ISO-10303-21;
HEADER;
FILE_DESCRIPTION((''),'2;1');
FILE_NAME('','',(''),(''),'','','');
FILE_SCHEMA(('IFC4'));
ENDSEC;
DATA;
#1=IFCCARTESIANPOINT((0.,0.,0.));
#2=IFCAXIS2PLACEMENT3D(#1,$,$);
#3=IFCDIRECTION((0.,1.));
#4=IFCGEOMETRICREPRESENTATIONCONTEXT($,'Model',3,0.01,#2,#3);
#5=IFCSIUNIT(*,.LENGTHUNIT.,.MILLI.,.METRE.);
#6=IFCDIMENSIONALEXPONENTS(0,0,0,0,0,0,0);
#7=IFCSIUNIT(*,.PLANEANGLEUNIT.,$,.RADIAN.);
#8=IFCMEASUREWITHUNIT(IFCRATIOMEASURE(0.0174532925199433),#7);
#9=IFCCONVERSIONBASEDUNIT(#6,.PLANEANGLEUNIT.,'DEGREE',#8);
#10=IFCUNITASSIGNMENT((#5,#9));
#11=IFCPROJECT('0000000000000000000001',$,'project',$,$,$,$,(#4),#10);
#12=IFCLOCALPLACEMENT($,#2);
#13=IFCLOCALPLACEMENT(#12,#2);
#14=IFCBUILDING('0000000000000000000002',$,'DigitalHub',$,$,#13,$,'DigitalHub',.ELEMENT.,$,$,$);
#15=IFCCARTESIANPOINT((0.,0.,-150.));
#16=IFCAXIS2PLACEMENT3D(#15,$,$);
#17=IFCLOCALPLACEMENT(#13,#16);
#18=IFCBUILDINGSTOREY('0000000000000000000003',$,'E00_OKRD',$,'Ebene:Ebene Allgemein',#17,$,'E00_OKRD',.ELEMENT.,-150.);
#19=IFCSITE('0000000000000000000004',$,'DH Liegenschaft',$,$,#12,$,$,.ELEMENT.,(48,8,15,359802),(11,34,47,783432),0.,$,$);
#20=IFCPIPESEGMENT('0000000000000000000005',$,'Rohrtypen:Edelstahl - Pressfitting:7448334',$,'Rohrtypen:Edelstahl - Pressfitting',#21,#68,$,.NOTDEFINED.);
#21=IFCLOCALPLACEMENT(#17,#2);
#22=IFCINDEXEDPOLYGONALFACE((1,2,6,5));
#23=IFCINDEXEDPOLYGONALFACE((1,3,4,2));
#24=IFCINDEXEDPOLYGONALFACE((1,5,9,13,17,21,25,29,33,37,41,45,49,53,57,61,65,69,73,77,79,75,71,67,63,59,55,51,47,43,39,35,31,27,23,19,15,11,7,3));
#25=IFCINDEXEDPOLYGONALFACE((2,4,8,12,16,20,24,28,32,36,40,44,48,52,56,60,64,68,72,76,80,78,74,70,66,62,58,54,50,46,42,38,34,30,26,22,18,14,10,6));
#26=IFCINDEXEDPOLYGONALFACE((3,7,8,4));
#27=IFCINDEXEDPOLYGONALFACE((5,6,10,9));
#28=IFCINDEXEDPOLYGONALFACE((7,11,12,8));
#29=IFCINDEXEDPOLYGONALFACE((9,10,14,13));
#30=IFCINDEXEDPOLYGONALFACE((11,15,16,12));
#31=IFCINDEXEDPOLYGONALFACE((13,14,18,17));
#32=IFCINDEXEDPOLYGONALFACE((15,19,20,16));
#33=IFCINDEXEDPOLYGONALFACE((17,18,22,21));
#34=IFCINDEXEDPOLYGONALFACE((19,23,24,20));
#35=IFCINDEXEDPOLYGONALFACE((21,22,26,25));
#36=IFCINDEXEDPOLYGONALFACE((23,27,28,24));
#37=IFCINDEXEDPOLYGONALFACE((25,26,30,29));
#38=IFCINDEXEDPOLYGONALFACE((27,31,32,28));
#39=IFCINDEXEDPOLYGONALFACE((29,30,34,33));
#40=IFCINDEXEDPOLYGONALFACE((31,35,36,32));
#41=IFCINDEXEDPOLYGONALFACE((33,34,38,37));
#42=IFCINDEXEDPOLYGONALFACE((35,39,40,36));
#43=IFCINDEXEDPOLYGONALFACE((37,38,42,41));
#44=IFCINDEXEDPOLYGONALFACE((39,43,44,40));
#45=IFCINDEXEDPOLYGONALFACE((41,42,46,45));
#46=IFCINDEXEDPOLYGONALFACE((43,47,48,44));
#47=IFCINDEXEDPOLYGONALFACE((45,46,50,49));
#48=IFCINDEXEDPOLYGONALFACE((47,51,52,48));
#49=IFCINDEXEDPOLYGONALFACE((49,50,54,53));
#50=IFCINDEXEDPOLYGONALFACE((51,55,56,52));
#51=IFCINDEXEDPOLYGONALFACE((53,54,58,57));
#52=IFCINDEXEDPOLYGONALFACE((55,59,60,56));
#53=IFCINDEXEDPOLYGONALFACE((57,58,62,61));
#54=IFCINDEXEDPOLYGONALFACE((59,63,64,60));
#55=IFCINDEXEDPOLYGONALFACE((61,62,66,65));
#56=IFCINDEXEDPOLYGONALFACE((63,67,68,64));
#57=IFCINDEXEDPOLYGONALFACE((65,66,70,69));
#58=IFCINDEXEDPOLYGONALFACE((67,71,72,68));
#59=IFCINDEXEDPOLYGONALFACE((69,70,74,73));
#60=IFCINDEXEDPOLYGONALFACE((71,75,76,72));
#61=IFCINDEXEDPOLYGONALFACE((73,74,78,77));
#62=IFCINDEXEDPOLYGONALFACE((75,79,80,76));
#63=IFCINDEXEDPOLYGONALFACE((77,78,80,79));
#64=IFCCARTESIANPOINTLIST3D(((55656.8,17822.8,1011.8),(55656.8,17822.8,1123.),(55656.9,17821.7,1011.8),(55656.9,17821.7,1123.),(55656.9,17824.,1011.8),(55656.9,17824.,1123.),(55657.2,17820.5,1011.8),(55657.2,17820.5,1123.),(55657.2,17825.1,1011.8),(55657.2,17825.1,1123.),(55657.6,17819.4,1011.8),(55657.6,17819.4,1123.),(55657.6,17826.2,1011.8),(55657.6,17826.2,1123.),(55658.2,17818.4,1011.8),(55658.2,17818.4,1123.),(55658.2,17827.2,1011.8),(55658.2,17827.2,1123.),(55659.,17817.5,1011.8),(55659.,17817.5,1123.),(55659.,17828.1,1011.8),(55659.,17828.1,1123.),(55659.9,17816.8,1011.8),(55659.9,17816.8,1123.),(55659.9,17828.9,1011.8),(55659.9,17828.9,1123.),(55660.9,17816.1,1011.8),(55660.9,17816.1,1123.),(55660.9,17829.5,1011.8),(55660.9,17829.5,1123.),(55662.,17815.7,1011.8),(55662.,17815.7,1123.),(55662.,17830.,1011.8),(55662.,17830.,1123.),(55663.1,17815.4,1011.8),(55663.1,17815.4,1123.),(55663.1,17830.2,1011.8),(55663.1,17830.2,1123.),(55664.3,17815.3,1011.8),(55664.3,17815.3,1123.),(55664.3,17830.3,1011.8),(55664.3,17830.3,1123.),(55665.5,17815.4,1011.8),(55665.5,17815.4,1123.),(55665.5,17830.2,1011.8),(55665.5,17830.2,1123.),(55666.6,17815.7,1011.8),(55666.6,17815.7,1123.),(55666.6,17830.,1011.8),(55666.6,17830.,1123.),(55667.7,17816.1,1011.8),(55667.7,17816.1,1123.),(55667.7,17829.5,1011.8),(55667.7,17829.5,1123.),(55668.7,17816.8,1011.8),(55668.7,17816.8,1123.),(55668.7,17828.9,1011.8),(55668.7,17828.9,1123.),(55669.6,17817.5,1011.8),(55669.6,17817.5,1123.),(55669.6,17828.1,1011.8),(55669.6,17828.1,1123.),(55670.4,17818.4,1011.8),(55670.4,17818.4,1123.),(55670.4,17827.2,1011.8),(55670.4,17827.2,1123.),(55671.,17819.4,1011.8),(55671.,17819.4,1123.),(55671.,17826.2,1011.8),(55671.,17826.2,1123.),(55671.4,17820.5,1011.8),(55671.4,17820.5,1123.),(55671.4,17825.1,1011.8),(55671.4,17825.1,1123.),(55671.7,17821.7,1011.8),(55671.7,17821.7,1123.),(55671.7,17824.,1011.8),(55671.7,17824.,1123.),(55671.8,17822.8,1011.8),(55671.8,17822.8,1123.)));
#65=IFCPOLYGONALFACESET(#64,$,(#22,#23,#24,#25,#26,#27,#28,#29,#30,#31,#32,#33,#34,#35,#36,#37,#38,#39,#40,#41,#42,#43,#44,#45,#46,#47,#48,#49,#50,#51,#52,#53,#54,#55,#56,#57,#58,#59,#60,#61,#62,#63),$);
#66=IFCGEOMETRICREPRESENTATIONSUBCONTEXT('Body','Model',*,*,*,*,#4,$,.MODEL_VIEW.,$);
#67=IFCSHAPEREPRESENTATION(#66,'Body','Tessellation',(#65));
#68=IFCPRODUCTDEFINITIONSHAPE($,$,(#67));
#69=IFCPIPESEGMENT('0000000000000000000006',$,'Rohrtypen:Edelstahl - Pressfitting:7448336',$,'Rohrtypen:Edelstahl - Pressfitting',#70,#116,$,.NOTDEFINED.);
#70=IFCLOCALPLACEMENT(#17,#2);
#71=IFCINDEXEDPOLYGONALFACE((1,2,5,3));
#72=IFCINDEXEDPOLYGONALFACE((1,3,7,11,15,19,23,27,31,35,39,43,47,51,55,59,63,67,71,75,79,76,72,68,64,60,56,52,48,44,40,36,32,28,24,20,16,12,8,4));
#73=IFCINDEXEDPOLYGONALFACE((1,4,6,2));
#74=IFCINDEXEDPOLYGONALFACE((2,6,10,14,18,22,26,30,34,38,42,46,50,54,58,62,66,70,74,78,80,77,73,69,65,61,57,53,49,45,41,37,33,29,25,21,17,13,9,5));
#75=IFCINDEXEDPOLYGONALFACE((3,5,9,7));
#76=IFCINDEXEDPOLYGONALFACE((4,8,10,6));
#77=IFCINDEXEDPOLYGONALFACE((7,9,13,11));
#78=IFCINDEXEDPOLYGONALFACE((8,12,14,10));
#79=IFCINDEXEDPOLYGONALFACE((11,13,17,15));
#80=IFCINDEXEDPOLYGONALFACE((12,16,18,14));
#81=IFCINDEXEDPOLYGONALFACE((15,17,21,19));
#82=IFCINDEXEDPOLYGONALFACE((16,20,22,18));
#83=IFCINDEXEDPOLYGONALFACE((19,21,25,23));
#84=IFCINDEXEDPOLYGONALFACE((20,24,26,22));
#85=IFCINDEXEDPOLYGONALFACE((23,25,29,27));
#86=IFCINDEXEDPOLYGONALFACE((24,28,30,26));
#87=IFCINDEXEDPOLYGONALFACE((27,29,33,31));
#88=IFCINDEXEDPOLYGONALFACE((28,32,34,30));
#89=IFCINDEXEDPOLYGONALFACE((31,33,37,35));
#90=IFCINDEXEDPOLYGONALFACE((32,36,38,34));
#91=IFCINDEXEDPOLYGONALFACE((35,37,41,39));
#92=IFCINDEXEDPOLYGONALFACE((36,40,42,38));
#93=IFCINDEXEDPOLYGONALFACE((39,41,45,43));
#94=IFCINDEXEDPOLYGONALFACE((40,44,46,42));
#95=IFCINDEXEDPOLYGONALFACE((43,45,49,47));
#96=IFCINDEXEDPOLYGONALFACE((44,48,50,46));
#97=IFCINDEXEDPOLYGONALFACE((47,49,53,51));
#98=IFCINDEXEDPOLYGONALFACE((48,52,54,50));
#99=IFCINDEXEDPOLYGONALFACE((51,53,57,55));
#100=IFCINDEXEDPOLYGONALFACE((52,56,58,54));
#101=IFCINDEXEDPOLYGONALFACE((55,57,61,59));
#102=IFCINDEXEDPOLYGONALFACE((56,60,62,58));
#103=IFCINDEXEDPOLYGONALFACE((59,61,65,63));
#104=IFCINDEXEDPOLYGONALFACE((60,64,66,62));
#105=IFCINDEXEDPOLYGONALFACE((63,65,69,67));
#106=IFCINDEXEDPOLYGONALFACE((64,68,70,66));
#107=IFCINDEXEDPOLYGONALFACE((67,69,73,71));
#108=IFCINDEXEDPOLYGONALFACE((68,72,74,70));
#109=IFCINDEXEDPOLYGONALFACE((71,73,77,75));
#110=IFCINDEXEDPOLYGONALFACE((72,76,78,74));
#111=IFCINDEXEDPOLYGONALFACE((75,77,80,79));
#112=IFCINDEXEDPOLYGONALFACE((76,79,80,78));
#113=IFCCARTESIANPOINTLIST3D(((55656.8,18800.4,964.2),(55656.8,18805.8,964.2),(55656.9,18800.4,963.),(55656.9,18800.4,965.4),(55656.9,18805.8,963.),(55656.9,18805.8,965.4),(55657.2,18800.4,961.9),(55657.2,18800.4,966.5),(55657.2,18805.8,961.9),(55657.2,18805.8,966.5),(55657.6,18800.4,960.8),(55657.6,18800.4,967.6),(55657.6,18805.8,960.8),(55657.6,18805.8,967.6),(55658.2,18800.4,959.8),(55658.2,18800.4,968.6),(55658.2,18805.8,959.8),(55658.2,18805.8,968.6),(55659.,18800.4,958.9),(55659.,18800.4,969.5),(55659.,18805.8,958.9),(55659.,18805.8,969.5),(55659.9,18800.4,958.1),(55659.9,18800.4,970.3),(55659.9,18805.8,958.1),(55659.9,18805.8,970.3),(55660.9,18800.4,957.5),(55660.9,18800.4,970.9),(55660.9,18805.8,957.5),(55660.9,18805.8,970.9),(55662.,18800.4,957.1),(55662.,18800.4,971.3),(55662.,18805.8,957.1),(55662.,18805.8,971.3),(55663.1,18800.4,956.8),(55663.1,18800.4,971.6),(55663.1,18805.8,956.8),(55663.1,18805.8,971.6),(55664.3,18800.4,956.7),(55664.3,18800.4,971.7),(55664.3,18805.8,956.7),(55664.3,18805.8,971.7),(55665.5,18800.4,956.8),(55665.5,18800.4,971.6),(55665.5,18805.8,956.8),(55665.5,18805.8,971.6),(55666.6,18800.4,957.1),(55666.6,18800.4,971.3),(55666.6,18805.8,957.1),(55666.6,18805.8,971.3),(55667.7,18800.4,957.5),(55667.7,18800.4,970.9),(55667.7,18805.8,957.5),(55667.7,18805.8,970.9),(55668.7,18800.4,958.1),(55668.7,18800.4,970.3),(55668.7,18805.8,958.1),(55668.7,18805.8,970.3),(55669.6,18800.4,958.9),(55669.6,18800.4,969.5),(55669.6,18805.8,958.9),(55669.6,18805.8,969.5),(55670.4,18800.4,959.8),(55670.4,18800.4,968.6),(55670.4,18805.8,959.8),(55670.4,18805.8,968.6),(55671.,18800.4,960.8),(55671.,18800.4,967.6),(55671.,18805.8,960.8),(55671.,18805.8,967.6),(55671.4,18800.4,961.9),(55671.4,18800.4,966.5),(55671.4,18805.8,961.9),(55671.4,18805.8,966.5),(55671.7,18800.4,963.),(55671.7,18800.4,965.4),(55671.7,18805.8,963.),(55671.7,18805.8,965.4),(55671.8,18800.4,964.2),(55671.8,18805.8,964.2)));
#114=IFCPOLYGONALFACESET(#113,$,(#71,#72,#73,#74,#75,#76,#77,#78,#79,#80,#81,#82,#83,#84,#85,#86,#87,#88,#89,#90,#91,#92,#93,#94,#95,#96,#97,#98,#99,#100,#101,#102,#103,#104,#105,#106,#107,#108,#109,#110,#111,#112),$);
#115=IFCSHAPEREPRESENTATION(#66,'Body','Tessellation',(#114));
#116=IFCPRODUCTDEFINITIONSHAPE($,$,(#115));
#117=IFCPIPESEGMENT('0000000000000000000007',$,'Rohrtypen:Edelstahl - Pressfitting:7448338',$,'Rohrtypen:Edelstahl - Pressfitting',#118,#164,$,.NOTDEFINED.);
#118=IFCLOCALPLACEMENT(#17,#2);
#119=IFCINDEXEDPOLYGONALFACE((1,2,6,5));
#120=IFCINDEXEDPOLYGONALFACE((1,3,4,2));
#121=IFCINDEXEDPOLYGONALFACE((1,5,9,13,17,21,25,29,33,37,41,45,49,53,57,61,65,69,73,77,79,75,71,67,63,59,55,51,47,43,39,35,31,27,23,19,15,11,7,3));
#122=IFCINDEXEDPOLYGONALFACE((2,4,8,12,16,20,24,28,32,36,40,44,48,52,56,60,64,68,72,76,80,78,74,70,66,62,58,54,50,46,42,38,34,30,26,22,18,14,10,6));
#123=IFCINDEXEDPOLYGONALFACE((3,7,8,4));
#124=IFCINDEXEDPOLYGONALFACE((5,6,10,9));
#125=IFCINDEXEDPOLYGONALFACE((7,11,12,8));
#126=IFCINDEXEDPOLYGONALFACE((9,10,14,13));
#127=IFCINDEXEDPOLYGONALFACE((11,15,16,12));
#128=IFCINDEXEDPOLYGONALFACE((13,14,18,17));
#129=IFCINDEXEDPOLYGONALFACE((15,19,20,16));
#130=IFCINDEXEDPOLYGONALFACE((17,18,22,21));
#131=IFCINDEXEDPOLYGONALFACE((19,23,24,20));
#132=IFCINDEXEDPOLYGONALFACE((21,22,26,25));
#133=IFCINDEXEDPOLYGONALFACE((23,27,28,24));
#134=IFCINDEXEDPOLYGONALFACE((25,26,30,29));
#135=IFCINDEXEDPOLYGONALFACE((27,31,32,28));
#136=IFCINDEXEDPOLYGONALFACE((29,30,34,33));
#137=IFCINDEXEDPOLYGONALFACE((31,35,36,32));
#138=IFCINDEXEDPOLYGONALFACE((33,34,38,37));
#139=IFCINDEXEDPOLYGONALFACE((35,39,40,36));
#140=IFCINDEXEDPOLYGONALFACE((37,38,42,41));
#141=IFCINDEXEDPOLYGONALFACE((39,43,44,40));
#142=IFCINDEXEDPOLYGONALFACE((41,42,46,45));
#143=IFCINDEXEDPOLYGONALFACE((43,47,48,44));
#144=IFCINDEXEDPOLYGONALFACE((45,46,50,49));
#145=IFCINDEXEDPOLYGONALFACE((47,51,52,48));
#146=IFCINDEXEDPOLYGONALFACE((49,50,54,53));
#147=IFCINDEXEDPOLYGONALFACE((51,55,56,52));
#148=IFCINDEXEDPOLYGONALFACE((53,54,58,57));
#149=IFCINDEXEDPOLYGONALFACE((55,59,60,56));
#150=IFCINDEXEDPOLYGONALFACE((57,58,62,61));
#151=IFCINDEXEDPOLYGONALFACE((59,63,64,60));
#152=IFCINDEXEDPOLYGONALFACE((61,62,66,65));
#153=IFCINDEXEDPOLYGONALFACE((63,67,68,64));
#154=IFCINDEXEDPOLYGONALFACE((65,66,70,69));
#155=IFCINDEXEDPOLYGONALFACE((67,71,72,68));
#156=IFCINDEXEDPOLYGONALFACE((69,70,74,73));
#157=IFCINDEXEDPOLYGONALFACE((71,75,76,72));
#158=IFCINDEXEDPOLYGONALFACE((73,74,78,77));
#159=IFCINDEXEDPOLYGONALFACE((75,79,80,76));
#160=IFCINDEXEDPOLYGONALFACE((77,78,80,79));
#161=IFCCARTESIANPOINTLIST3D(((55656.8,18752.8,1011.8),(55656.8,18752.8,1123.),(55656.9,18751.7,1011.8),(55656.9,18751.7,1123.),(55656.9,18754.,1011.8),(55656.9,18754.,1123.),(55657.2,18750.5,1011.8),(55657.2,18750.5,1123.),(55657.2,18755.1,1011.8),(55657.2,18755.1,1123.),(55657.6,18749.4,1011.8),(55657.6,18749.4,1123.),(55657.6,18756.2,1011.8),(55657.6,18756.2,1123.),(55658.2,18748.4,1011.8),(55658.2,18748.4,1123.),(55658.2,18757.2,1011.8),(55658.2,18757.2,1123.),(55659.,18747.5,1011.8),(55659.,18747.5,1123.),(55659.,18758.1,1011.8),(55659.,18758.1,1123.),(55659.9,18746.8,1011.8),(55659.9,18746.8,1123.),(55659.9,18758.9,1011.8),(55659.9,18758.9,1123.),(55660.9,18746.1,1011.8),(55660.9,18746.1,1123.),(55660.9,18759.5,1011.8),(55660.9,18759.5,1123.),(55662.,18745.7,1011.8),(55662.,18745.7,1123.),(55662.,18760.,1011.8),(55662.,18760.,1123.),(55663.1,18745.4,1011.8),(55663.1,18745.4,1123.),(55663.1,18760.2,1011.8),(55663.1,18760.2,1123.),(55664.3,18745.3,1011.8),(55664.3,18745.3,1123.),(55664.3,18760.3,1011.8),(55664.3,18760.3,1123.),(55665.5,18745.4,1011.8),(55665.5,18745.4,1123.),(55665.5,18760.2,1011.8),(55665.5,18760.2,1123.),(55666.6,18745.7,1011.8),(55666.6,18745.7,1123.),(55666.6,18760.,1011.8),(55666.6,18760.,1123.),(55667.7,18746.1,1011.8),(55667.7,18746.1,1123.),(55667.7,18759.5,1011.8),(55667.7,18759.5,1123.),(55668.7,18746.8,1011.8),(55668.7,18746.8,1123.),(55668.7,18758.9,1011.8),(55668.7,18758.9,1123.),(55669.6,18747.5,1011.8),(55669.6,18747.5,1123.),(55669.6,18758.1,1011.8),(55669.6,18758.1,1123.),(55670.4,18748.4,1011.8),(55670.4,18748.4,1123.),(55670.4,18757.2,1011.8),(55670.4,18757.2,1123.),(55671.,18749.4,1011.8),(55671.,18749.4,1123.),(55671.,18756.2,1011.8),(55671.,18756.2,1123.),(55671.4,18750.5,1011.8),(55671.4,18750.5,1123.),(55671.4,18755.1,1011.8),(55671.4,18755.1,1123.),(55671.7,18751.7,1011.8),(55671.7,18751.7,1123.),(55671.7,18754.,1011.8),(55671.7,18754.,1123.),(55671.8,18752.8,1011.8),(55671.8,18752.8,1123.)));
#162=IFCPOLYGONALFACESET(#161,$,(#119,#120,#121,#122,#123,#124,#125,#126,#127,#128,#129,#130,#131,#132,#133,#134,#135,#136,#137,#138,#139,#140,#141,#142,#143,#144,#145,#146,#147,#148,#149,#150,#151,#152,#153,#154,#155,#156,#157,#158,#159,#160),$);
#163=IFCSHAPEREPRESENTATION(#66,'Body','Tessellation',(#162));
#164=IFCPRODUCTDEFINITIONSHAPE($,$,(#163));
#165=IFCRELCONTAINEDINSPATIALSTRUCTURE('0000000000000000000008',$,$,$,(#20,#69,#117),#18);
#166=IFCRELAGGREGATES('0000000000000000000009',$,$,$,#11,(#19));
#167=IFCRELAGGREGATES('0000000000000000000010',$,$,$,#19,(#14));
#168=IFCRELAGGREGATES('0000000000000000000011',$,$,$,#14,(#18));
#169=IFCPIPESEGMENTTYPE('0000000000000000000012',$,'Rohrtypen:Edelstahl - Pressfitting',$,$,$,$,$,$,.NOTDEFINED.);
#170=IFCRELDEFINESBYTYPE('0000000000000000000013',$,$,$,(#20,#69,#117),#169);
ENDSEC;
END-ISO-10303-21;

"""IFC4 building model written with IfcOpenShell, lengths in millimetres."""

from ifc_helpers import new_model, entity, si_unit, converted_unit, direction, frame, origin, place, context, subcontext, project, spatial, indexed_curve, outline, extrude, type_object, element, save


model = new_model("IFC4")

# Units and contexts
model_context = context("Model", 3, precision=0.01, world=origin(), true_north=direction((0.0, 1.0)))
body_context = subcontext(model_context, "Body", "Model", "MODEL_VIEW")
ifc_project = project(units=[si_unit("LENGTHUNIT", "METRE", prefix="MILLI"), converted_unit("PLANEANGLEUNIT", "DEGREE", entity("IfcRatioMeasure", 0.0174532925199433), si_unit("PLANEANGLEUNIT", "RADIAN"), dimensions=[0, 0, 0, 0, 0, 0, 0])], contexts=[model_context])

# Site, building, storey
site_placement = place(None, origin())
site = spatial("IfcSite", under=ifc_project, at=site_placement, Name="DH Liegenschaft", CompositionType="ELEMENT", RefLatitude=(48, 8, 15, 359802), RefLongitude=(11, 34, 47, 783432), RefElevation=0.0)
building_placement = place(site_placement, origin())
building = spatial("IfcBuilding", under=site, at=building_placement, Name="DigitalHub", LongName="DigitalHub", CompositionType="ELEMENT")
storey_placement = place(building_placement, frame((0.0, 0.0, -150.0)))
storey = spatial("IfcBuildingStorey", under=building, at=storey_placement, Name="E00_OKRD", ObjectType="Ebene:Ebene Allgemein", LongName="E00_OKRD", CompositionType="ELEMENT", Elevation=-150.0)

# Pipe segments
pipe_segment_type_1 = type_object("IfcPipeSegmentType", Name="Rohrtypen:Edelstahl - Pressfitting", PredefinedType="NOTDEFINED")
pipe_segment_1_placement = place(storey_placement, frame((55655.2, 17813.7, 1011.8)))
element("IfcPipeSegment", 1, at=pipe_segment_1_placement, inside=storey, type_object=pipe_segment_type_1, Name="Rohrtypen:Edelstahl - Pressfitting:7448334", ObjectType="Rohrtypen:Edelstahl - Pressfitting", PredefinedType="NOTDEFINED", context=body_context, shape_type="SweptSolid", body=[
    extrude(outline(indexed_curve([(7.5, 0.0), (7.4, 1.2), (7.1, 2.3), (6.7, 3.4), (6.1, 4.4), (5.3, 5.3), (4.4, 6.1), (3.4, 6.7), (2.3, 7.1), (1.2, 7.4), (0.0, 7.5), (-1.2, 7.4), (-2.3, 7.1), (-3.4, 6.7), (-4.4, 6.1), (-5.3, 5.3), (-6.1, 4.4), (-6.7, 3.4), (-7.1, 2.3), (-7.4, 1.2), (-7.5, 0.0), (-7.4, -1.2), (-7.1, -2.3), (-6.7, -3.4), (-6.1, -4.4), (-5.3, -5.3), (-4.4, -6.1), (-3.4, -6.7), (-2.3, -7.1), (-1.2, -7.4), (0.0, -7.5), (1.2, -7.4), (2.3, -7.1), (3.4, -6.7), (4.4, -6.1), (5.3, -5.3), (6.1, -4.4), (6.7, -3.4), (7.1, -2.3), (7.4, -1.2), (7.5, 0.0)], self_intersect=False)), frame((9.1, 9.1, 0.0), z_axis=(0.000005, 0.0, 1.0), x_axis=(-1.0, 0.0, 0.000005)), (0.0, 0.0, 1.0), 111.2),
])
pipe_segment_2_placement = place(storey_placement, frame((55655.2, 18800.4, 955.1)))
element("IfcPipeSegment", 2, at=pipe_segment_2_placement, inside=storey, type_object=pipe_segment_type_1, Name="Rohrtypen:Edelstahl - Pressfitting:7448336", ObjectType="Rohrtypen:Edelstahl - Pressfitting", PredefinedType="NOTDEFINED", context=body_context, shape_type="SweptSolid", body=[
    extrude(outline(indexed_curve([(7.5, 0.0), (7.4, 1.2), (7.1, 2.3), (6.7, 3.4), (6.1, 4.4), (5.3, 5.3), (4.4, 6.1), (3.4, 6.7), (2.3, 7.1), (1.2, 7.4), (0.0, 7.5), (-1.2, 7.4), (-2.3, 7.1), (-3.4, 6.7), (-4.4, 6.1), (-5.3, 5.3), (-6.1, 4.4), (-6.7, 3.4), (-7.1, 2.3), (-7.4, 1.2), (-7.5, 0.0), (-7.4, -1.2), (-7.1, -2.3), (-6.7, -3.4), (-6.1, -4.4), (-5.3, -5.3), (-4.4, -6.1), (-3.4, -6.7), (-2.3, -7.1), (-1.2, -7.4), (0.0, -7.5), (1.2, -7.4), (2.3, -7.1), (3.4, -6.7), (4.4, -6.1), (5.3, -5.3), (6.1, -4.4), (6.7, -3.4), (7.1, -2.3), (7.4, -1.2), (7.5, 0.0)], self_intersect=False)), frame((9.1, 0.0, 9.1), z_axis=(0.0, 1.0, 0.0), x_axis=(-1.0, 0.0, 0.0)), (0.0, 0.0, 1.0), 5.4),
])
pipe_segment_3_placement = place(storey_placement, frame((55655.2, 18743.7, 1011.8)))
element("IfcPipeSegment", 3, at=pipe_segment_3_placement, inside=storey, type_object=pipe_segment_type_1, Name="Rohrtypen:Edelstahl - Pressfitting:7448338", ObjectType="Rohrtypen:Edelstahl - Pressfitting", PredefinedType="NOTDEFINED", context=body_context, shape_type="SweptSolid", body=[
    extrude(outline(indexed_curve([(7.5, 0.0), (7.4, 1.2), (7.1, 2.3), (6.7, 3.4), (6.1, 4.4), (5.3, 5.3), (4.4, 6.1), (3.4, 6.7), (2.3, 7.1), (1.2, 7.4), (0.0, 7.5), (-1.2, 7.4), (-2.3, 7.1), (-3.4, 6.7), (-4.4, 6.1), (-5.3, 5.3), (-6.1, 4.4), (-6.7, 3.4), (-7.1, 2.3), (-7.4, 1.2), (-7.5, 0.0), (-7.4, -1.2), (-7.1, -2.3), (-6.7, -3.4), (-6.1, -4.4), (-5.3, -5.3), (-4.4, -6.1), (-3.4, -6.7), (-2.3, -7.1), (-1.2, -7.4), (0.0, -7.5), (1.2, -7.4), (2.3, -7.1), (3.4, -6.7), (4.4, -6.1), (5.3, -5.3), (6.1, -4.4), (6.7, -3.4), (7.1, -2.3), (7.4, -1.2), (7.5, 0.0)], self_intersect=False)), frame((9.1, 9.1, 0.0), z_axis=(0.000002, 0.0, 1.0), x_axis=(-1.0, 0.0, 0.000002)), (0.0, 0.0, 1.0), 111.2),
])

save(model, "model.ifc")
